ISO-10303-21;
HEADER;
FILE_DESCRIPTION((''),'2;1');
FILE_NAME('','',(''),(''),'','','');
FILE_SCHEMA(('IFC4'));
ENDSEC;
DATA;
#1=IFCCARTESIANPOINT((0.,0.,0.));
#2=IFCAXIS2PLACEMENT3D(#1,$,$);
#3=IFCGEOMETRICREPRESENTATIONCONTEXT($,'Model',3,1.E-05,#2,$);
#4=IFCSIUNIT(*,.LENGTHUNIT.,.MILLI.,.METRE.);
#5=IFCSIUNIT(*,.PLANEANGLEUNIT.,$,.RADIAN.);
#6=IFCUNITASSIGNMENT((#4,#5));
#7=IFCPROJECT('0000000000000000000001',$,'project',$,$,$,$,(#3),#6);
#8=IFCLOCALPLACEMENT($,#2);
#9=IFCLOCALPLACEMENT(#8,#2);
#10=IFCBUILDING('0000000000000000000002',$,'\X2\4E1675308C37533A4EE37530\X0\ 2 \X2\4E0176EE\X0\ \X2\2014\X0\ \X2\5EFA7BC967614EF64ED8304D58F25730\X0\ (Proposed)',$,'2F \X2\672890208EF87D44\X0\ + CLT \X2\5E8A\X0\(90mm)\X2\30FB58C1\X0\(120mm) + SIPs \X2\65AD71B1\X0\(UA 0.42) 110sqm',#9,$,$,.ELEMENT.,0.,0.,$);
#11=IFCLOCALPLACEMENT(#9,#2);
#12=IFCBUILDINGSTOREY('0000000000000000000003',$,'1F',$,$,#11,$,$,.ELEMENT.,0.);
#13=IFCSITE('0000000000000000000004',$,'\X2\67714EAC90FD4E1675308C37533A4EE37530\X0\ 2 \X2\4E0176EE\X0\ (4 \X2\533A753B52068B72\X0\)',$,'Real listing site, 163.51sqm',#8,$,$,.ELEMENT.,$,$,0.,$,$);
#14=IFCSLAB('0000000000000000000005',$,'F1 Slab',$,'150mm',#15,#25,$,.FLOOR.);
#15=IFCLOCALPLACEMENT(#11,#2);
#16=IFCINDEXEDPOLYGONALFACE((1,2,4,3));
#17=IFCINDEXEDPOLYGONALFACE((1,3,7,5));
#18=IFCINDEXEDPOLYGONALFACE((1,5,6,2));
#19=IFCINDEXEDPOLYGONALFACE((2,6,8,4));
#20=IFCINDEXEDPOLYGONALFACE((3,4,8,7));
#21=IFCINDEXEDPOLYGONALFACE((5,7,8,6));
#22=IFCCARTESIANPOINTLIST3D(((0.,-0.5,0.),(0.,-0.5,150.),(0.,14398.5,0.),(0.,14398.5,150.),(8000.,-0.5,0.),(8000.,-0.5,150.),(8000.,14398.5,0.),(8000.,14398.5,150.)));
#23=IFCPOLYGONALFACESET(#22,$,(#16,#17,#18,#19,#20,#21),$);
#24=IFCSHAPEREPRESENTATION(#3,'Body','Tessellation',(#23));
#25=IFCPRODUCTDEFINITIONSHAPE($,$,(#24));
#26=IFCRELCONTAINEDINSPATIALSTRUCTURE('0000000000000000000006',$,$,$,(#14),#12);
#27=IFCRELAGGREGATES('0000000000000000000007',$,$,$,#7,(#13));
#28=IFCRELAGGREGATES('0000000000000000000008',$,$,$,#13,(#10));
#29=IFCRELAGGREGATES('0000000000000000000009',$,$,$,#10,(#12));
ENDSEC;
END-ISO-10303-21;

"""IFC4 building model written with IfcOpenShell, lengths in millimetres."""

from ifc_helpers import new_model, si_unit, frame_2d, origin, place, context, project, spatial, rectangle, extrude, element, save


model = new_model("IFC4")

# Units and contexts
model_context = context("Model", 3, precision=1e-05, world=origin())
ifc_project = project(units=[si_unit("LENGTHUNIT", "METRE", prefix="MILLI"), si_unit("PLANEANGLEUNIT", "RADIAN")], contexts=[model_context])

# Site, building, storey
site_placement = place(None, origin())
site = spatial("IfcSite", under=ifc_project, at=site_placement, Name="東京都世田谷区代田 2 丁目 (4 区画分譲)", ObjectType="Real listing site, 163.51sqm", CompositionType="ELEMENT", RefElevation=0.0)
building_placement = place(site_placement, origin())
building = spatial("IfcBuilding", under=site, at=building_placement, Name="世田谷区代田 2 丁目 — 建築条件付き売地 (Proposed)", ObjectType="2F 木造軸組 + CLT 床(90mm)・壁(120mm) + SIPs 断熱(UA 0.42) 110sqm", CompositionType="ELEMENT", ElevationOfRefHeight=0.0, ElevationOfTerrain=0.0)
storey_placement = place(building_placement, origin())
storey = spatial("IfcBuildingStorey", under=building, at=storey_placement, Name="1F", CompositionType="ELEMENT", Elevation=0.0)

# Slab
slab_placement = place(storey_placement, origin())
element("IfcSlab", 1, at=slab_placement, inside=storey, Name="F1 Slab", ObjectType="150mm", PredefinedType="FLOOR", context=model_context, shape_type="SweptSolid", body=[
    extrude(rectangle(XDim=8000.0, YDim=14399.0, at=frame_2d((4000.0, 7199.0))), origin(), (0.0, 0.0, 1.0), 150.0),
])

save(model, "model.ifc")
